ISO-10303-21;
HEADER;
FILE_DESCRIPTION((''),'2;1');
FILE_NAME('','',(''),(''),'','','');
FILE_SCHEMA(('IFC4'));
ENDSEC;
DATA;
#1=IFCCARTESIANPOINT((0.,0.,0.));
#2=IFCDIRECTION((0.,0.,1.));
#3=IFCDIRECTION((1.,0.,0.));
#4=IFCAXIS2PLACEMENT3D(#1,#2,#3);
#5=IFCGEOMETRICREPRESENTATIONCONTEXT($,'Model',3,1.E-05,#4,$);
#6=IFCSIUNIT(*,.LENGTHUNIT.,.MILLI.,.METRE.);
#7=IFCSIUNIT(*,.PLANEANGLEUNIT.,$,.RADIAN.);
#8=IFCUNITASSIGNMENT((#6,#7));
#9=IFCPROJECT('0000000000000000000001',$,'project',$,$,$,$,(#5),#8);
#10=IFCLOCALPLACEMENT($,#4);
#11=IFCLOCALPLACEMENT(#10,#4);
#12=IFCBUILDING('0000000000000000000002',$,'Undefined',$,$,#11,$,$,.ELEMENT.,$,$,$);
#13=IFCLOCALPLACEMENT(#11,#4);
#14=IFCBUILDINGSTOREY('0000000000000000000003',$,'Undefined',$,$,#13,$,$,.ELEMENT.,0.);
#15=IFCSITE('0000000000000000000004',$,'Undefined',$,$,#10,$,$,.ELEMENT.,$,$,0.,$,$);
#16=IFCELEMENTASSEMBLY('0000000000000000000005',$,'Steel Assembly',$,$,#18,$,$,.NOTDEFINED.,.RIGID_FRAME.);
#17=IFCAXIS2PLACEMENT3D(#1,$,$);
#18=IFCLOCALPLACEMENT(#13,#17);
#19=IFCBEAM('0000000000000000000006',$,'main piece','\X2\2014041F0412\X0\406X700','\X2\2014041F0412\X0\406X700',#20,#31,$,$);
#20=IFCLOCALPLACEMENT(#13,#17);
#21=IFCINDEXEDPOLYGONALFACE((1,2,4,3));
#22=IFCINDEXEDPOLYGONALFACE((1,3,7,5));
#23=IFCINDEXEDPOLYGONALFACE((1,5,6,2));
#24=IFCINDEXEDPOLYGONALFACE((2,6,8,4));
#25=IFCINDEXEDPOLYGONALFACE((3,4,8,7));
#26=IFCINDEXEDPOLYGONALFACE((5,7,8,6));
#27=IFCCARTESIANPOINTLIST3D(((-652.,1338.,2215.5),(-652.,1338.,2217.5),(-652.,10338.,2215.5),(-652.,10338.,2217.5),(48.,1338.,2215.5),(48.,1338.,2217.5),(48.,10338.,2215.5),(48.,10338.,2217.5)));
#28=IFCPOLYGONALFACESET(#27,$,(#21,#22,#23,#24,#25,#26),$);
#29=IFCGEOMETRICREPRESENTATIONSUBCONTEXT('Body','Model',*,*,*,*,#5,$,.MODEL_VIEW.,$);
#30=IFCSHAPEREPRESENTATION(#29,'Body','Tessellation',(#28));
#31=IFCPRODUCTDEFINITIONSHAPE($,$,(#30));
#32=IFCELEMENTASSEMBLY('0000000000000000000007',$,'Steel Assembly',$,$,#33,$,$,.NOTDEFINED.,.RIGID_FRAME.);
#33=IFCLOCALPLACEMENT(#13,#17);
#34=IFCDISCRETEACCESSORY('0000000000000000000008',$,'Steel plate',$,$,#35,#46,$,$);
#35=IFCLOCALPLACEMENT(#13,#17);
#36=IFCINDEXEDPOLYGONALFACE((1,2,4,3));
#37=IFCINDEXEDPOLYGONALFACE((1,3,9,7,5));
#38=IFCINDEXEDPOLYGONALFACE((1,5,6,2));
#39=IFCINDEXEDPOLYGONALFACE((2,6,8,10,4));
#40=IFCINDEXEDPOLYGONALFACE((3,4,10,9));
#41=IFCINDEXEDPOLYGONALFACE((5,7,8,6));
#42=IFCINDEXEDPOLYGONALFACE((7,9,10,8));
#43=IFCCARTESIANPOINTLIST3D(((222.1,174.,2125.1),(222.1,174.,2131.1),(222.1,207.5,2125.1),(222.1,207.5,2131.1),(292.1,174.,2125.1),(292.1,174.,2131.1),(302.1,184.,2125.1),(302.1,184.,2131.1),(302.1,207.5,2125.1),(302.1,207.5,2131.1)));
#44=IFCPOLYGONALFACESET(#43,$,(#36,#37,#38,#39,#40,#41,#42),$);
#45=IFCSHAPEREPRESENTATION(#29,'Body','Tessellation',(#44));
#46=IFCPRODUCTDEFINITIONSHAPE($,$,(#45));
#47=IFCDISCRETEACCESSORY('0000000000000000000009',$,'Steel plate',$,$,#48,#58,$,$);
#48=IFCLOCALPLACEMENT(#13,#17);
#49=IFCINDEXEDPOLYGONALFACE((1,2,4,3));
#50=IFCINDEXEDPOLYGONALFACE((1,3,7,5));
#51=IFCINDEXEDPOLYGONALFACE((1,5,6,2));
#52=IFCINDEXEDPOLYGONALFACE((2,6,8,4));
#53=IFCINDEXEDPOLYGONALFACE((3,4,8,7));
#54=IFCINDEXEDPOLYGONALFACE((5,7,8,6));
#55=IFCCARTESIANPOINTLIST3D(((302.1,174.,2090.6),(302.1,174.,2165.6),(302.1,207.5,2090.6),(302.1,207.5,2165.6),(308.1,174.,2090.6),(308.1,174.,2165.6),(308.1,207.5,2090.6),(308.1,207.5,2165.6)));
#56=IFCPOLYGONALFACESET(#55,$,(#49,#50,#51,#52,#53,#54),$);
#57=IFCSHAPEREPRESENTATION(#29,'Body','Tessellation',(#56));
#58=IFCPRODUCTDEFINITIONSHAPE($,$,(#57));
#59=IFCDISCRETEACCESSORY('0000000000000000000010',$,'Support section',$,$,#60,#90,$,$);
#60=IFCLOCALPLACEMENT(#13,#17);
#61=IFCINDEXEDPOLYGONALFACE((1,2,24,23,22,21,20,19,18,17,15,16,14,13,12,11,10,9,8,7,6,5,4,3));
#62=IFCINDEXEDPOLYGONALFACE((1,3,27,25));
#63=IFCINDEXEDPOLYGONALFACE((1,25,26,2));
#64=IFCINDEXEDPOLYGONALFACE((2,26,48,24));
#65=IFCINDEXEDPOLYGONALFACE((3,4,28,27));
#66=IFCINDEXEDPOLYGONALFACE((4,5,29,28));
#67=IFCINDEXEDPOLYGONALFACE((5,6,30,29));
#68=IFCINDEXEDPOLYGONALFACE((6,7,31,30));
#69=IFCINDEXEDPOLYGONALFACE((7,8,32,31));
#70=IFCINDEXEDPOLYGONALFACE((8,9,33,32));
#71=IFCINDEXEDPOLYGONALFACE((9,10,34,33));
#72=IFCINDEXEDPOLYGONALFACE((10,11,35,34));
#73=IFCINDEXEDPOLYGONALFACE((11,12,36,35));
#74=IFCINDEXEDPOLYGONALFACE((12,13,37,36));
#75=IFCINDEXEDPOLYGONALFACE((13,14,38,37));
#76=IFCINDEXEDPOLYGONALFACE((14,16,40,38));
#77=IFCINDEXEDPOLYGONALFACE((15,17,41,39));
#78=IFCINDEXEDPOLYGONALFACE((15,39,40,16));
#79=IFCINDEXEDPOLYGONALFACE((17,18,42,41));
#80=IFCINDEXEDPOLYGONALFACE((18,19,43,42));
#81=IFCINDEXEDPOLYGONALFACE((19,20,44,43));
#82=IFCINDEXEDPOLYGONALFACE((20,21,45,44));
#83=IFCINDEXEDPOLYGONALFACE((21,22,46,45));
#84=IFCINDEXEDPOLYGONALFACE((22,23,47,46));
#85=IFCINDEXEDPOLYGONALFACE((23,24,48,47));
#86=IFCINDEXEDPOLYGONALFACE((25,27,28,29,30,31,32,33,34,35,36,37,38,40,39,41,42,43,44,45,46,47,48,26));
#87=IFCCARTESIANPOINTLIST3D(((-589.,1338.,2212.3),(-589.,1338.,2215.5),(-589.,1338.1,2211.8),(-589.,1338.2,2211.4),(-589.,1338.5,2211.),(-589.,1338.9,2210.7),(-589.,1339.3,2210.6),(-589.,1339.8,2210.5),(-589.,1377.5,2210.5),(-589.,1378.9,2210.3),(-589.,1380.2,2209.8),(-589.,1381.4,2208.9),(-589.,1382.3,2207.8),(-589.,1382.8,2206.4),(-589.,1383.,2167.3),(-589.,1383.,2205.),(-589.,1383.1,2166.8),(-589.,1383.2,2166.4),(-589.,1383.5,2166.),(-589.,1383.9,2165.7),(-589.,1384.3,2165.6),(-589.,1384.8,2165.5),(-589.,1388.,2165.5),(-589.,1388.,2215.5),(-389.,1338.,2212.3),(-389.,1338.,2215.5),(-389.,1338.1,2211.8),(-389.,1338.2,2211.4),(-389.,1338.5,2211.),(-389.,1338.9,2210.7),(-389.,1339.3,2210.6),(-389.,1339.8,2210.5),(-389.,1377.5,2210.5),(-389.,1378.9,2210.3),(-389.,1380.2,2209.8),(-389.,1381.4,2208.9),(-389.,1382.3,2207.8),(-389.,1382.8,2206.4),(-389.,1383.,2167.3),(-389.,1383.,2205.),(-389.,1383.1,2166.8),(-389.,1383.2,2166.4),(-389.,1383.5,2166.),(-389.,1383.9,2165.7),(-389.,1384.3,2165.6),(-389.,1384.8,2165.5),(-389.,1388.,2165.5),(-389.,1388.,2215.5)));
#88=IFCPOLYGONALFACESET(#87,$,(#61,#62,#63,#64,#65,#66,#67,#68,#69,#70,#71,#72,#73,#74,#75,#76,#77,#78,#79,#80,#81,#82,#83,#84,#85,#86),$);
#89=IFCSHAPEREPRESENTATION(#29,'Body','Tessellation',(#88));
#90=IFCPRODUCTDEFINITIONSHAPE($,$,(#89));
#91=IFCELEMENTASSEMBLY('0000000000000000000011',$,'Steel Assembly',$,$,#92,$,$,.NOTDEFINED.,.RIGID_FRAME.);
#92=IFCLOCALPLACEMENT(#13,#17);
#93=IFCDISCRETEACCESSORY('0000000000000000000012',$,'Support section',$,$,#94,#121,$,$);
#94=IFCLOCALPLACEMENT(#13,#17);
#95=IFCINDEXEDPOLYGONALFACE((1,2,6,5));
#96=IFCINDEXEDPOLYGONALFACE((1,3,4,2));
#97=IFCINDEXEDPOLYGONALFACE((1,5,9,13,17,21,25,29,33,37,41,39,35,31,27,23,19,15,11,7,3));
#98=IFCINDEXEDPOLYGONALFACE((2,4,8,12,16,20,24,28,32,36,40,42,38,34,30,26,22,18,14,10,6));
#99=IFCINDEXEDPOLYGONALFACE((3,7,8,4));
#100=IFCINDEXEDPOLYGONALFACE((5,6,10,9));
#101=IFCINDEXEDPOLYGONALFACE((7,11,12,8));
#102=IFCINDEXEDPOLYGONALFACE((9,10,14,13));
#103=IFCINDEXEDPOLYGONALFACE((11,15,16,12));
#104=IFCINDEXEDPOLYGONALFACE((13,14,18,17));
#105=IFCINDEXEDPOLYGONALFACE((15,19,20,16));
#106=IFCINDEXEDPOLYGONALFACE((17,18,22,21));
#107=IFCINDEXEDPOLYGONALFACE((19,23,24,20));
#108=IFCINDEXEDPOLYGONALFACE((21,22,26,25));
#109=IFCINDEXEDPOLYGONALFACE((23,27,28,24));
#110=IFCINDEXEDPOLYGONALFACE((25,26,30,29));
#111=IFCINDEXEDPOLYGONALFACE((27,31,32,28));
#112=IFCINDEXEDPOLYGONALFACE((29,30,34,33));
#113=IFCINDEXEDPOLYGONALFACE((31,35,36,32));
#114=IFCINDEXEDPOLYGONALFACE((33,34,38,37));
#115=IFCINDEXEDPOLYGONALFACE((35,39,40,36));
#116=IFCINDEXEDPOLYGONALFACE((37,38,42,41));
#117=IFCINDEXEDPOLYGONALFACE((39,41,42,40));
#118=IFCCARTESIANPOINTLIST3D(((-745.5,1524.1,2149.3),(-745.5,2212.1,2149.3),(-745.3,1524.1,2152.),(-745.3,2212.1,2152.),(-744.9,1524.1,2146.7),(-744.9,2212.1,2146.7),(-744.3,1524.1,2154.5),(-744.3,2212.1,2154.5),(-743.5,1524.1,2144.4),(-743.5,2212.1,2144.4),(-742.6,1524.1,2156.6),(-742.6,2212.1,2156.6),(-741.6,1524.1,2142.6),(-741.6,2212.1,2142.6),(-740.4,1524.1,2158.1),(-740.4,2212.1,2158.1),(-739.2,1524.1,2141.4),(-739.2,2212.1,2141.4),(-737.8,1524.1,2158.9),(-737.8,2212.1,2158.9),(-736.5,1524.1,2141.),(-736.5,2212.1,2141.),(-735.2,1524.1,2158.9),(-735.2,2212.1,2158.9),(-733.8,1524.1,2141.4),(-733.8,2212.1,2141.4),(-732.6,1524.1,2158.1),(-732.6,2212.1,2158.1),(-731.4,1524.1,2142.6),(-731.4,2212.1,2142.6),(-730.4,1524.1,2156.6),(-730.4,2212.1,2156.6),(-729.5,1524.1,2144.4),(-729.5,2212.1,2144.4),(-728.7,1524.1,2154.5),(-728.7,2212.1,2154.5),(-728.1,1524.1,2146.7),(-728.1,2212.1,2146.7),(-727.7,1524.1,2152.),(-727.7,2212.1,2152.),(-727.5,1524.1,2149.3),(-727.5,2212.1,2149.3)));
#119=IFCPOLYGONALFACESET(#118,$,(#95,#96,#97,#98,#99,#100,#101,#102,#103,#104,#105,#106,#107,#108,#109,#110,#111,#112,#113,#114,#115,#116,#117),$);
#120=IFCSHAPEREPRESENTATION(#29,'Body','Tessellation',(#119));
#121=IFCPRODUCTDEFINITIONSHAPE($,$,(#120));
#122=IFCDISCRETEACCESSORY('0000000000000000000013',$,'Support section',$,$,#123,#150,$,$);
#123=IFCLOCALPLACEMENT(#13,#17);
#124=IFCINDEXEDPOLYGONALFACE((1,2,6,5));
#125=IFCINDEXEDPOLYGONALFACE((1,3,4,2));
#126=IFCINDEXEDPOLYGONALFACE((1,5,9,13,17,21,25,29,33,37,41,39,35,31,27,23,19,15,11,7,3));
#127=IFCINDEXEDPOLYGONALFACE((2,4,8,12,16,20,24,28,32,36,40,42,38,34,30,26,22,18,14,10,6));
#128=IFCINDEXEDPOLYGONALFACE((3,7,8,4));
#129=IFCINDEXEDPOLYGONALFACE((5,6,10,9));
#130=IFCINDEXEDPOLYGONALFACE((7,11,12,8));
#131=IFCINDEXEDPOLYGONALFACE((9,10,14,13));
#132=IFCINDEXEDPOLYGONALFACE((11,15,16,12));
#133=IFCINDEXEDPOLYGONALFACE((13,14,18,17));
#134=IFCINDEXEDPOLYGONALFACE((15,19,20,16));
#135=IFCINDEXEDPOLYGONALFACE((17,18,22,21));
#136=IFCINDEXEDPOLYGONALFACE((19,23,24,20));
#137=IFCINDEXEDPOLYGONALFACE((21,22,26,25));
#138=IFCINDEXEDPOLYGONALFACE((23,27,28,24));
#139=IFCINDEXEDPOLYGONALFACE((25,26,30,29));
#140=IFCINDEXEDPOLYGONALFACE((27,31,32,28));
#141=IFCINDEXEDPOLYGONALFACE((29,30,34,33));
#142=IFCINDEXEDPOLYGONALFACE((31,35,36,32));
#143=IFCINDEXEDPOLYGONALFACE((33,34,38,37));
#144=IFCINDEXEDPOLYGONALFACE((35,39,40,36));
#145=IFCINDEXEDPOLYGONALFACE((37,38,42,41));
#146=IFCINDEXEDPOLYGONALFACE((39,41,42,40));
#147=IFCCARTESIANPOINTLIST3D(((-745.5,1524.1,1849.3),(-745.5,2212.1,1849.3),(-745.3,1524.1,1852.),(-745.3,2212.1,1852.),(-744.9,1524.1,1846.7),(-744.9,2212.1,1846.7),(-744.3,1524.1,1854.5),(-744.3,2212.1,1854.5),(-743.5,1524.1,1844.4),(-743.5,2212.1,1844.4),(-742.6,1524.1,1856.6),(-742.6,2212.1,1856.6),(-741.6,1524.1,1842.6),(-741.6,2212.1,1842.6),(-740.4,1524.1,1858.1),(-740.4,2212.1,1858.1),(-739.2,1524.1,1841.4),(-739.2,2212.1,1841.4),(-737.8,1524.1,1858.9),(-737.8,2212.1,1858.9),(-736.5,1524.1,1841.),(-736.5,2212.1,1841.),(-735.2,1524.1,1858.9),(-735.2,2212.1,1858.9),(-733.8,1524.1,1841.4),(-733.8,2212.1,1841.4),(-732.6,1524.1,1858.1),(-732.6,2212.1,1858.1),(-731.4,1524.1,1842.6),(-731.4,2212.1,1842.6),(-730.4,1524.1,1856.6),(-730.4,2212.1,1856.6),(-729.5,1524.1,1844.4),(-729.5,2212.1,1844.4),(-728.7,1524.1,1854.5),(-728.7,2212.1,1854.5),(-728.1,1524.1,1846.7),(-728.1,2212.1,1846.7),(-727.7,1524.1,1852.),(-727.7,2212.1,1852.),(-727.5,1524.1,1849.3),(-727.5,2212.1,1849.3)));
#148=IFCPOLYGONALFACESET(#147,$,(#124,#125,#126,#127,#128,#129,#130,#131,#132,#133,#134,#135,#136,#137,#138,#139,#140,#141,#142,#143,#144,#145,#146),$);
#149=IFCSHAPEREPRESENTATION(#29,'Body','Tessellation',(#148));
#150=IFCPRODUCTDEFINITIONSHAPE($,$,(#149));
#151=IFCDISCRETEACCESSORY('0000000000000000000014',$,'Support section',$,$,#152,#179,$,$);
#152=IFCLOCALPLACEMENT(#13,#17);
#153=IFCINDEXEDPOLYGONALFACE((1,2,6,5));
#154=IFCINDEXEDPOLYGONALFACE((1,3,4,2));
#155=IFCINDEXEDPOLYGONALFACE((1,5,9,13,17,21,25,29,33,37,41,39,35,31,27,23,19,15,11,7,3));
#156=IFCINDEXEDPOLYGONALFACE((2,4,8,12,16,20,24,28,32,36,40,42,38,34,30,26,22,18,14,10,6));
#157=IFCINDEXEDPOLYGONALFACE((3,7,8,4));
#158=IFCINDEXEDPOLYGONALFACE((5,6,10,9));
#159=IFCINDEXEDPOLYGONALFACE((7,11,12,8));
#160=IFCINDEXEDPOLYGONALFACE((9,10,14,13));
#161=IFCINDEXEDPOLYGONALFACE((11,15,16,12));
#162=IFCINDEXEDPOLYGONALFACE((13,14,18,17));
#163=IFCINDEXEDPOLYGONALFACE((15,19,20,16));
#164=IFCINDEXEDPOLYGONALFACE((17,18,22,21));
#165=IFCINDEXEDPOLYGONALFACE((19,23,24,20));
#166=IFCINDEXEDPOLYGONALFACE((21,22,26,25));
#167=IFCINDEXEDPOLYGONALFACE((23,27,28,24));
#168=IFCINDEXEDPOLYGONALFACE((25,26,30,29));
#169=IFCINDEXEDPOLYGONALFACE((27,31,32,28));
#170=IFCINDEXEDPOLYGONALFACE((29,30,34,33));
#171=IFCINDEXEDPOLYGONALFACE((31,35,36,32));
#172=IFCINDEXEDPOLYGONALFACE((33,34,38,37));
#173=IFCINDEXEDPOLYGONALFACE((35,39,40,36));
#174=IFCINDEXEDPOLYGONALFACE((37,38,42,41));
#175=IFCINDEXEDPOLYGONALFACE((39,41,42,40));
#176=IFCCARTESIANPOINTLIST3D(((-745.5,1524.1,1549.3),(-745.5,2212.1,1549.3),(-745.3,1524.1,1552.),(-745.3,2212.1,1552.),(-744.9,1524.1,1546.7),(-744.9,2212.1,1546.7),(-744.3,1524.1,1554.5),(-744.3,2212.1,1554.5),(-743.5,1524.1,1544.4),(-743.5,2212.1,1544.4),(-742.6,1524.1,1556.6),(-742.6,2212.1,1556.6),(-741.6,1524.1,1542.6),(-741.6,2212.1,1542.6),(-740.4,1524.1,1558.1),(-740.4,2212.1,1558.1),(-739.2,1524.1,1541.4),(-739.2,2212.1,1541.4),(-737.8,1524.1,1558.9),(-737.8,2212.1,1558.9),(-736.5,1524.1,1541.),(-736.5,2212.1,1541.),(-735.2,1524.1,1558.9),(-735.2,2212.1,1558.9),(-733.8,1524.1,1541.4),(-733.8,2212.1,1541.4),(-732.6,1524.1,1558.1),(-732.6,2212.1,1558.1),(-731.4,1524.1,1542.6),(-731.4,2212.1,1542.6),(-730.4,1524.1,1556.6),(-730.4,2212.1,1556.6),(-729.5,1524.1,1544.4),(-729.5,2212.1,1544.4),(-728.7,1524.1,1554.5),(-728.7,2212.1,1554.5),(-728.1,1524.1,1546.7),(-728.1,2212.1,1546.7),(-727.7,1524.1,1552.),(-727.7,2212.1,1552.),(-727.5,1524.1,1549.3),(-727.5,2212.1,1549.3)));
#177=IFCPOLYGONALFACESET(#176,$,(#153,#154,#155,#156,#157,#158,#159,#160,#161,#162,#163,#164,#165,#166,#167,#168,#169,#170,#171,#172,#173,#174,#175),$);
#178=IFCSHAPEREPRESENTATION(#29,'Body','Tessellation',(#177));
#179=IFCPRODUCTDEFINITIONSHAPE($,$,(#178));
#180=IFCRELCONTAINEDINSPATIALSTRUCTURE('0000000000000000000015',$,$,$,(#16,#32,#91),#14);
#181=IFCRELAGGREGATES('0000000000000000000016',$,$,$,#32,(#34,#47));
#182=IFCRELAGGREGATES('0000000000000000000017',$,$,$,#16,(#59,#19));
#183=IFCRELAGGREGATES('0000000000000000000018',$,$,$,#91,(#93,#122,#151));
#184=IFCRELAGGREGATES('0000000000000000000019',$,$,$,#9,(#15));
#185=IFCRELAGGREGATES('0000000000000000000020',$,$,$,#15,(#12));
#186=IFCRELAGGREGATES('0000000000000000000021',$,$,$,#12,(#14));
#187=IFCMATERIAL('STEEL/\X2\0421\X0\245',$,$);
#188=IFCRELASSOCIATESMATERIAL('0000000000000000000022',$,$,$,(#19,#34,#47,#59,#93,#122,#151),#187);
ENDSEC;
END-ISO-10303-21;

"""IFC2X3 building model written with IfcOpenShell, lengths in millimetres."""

from ifc_helpers import new_model, si_unit, frame, origin_with_axes, origin_2d_with_axis, place, context, subcontext, project, spatial, polyline, rectangle, circle, l_section, outline, extrude, material, element, aggregate, save


model = new_model("IFC2X3")

# Units and contexts
model_context = context("Model", 3, precision=1e-05, world=origin_with_axes())
body_context = subcontext(model_context, "Body", "Model", "MODEL_VIEW")
ifc_project = project(units=[si_unit("LENGTHUNIT", "METRE", prefix="MILLI"), si_unit("PLANEANGLEUNIT", "RADIAN")], contexts=[model_context])

# Site, building, storey
site_placement = place(None, origin_with_axes())
site = spatial("IfcSite", under=ifc_project, at=site_placement, Name="Undefined", CompositionType="ELEMENT", RefElevation=0.0)
building_placement = place(site_placement, origin_with_axes())
building = spatial("IfcBuilding", under=site, at=building_placement, Name="Undefined", CompositionType="ELEMENT")
storey_placement = place(building_placement, origin_with_axes())
storey = spatial("IfcBuildingStorey", under=building, at=storey_placement, Name="Undefined", CompositionType="ELEMENT", Elevation=0.0)

# Shared definitions
ifc_material_1 = material(Name="STEEL/С245")

# Element assembly, beam
assembly_1_placement = place(storey_placement, origin_with_axes())
assembly_1 = element("IfcElementAssembly", 1, at=assembly_1_placement, inside=storey, Name="Steel Assembly", AssemblyPlace="NOTDEFINED", PredefinedType="RIGID_FRAME")
beam_1_placement = place(assembly_1_placement, frame((-302.0, 1338.0, 2216.5), z_axis=(0.0, 0.0, -1.0), x_axis=(0.0, 1.0, 0.0)))
beam_1 = element("IfcBeam", 2, at=beam_1_placement, material=ifc_material_1, Name="main piece", Description="—ПВ406X700", ObjectType="—ПВ406X700", context=body_context, shape_type="SweptSolid", body=[
    extrude(rectangle(XDim=700.0, YDim=2.0, at=origin_2d_with_axis()), frame((9000.0, 0.0, 0.0), z_axis=(-1.0, 0.0, 0.0), x_axis=(0.0, -1.0, 0.0)), (0.0, 0.0, 1.0), 9000.0),
])

# Element assembly, discrete accessories, opening
assembly_2_placement = place(storey_placement, origin_with_axes())
assembly_2 = element("IfcElementAssembly", 3, at=assembly_2_placement, inside=storey, Name="Steel Assembly", AssemblyPlace="NOTDEFINED", PredefinedType="RIGID_FRAME")
discrete_accessory_1_placement = place(assembly_2_placement, frame((302.1, 207.5, 2128.1), z_axis=(0.0, 0.0, 1.0), x_axis=(-1.0, 0.0, 0.0)))
discrete_accessory_1 = element("IfcDiscreteAccessory", 4, at=discrete_accessory_1_placement, material=ifc_material_1, Name="Steel plate", context=body_context, shape_type="SweptSolid", body=[
    extrude(outline(polyline([(0.0, 0.0), (80.0, 0.0), (80.0, 33.5), (10.0, 33.5), (0.0, 23.5), (0.0, 0.0)])), frame((0.0, 0.0, -3.0), z_axis=(0.0, 0.0, 1.0), x_axis=(1.0, 0.0, 0.0)), (0.0, 0.0, 1.0), 6.0),
])
discrete_accessory_2_placement = place(assembly_2_placement, frame((305.1, 207.5, 2165.6), z_axis=(-1.0, 0.0, 0.0), x_axis=(0.0, 0.0, -1.0)))
discrete_accessory_2 = element("IfcDiscreteAccessory", 5, at=discrete_accessory_2_placement, material=ifc_material_1, Name="Steel plate", context=body_context, shape_type="SweptSolid", body=[
    extrude(outline(polyline([(0.0, 0.0), (75.0, 0.0), (75.0, 75.0), (0.0, 75.0), (0.0, 0.0)])), frame((0.0, 0.0, -3.0), z_axis=(0.0, 0.0, 1.0), x_axis=(1.0, 0.0, 0.0)), (0.0, 0.0, 1.0), 6.0),
])
opening_1_placement = place(assembly_2_placement, frame((305.1, 207.5, 2165.6), z_axis=(-1.0, 0.0, 0.0), x_axis=(0.0, 0.0, -1.0)))
element("IfcOpeningElement", 6, at=opening_1_placement, cuts=discrete_accessory_2, ObjectType="Recess", context=body_context, shape_type="SweptSolid", body=[
    extrude(outline(polyline([(0.0, 0.0), (75.0, 0.0), (75.0, 150.0), (0.0, 150.0), (0.0, 0.0)])), frame((112.5, 108.5, 6.0), z_axis=(0.0, 0.0, -1.0), x_axis=(0.0, -1.0, 0.0)), (0.0, 0.0, 1.0), 12.0),
])
aggregate(assembly_2, [discrete_accessory_1, discrete_accessory_2])

# Discrete accessory
discrete_accessory_3_placement = place(assembly_1_placement, frame((-589.0, 1363.0, 2190.5), z_axis=(0.0, -1.0, 0.0), x_axis=(1.0, 0.0, 0.0)))
discrete_accessory_3 = element("IfcDiscreteAccessory", 7, at=discrete_accessory_3_placement, material=ifc_material_1, Name="Support section", context=body_context, shape_type="SweptSolid", body=[
    extrude(l_section(Depth=50.0, Width=50.0, Thickness=5.0, FilletRadius=5.5, EdgeRadius=1.8, at=origin_2d_with_axis()), frame((200.0, 0.0, 0.0), z_axis=(-1.0, 0.0, 0.0), x_axis=(0.0, -1.0, 0.0)), (0.0, 0.0, 1.0), 200.0),
])
aggregate(assembly_1, [discrete_accessory_3, beam_1])

# Element assembly, discrete accessories
assembly_3_placement = place(storey_placement, origin_with_axes())
assembly_3 = element("IfcElementAssembly", 8, at=assembly_3_placement, inside=storey, Name="Steel Assembly", AssemblyPlace="NOTDEFINED", PredefinedType="RIGID_FRAME")
discrete_accessory_4_placement = place(assembly_3_placement, frame((-736.5, 1524.1, 2150.0), z_axis=(1.0, 0.0, 0.0), x_axis=(0.0, 1.0, 0.0)))
discrete_accessory_4 = element("IfcDiscreteAccessory", 9, at=discrete_accessory_4_placement, material=ifc_material_1, Name="Support section", context=body_context, shape_type="SweptSolid", body=[
    extrude(circle(Radius=9.0, at=origin_2d_with_axis()), frame((688.0, 0.0, 0.0), z_axis=(-1.0, 0.0, 0.0), x_axis=(0.0, -1.0, 0.0)), (0.0, 0.0, 1.0), 688.0),
])
discrete_accessory_5_placement = place(assembly_3_placement, frame((-736.5, 1524.1, 1850.0), z_axis=(1.0, 0.0, 0.0), x_axis=(0.0, 1.0, 0.0)))
discrete_accessory_5 = element("IfcDiscreteAccessory", 10, at=discrete_accessory_5_placement, material=ifc_material_1, Name="Support section", context=body_context, shape_type="SweptSolid", body=[
    extrude(circle(Radius=9.0, at=origin_2d_with_axis()), frame((688.0, 0.0, 0.0), z_axis=(-1.0, 0.0, 0.0), x_axis=(0.0, -1.0, 0.0)), (0.0, 0.0, 1.0), 688.0),
])
discrete_accessory_6_placement = place(assembly_3_placement, frame((-736.5, 1524.1, 1550.0), z_axis=(1.0, 0.0, 0.0), x_axis=(0.0, 1.0, 0.0)))
discrete_accessory_6 = element("IfcDiscreteAccessory", 11, at=discrete_accessory_6_placement, material=ifc_material_1, Name="Support section", context=body_context, shape_type="SweptSolid", body=[
    extrude(circle(Radius=9.0, at=origin_2d_with_axis()), frame((688.0, 0.0, 0.0), z_axis=(-1.0, 0.0, 0.0), x_axis=(0.0, -1.0, 0.0)), (0.0, 0.0, 1.0), 688.0),
])
aggregate(assembly_3, [discrete_accessory_4, discrete_accessory_5, discrete_accessory_6])

save(model, "model.ifc")
